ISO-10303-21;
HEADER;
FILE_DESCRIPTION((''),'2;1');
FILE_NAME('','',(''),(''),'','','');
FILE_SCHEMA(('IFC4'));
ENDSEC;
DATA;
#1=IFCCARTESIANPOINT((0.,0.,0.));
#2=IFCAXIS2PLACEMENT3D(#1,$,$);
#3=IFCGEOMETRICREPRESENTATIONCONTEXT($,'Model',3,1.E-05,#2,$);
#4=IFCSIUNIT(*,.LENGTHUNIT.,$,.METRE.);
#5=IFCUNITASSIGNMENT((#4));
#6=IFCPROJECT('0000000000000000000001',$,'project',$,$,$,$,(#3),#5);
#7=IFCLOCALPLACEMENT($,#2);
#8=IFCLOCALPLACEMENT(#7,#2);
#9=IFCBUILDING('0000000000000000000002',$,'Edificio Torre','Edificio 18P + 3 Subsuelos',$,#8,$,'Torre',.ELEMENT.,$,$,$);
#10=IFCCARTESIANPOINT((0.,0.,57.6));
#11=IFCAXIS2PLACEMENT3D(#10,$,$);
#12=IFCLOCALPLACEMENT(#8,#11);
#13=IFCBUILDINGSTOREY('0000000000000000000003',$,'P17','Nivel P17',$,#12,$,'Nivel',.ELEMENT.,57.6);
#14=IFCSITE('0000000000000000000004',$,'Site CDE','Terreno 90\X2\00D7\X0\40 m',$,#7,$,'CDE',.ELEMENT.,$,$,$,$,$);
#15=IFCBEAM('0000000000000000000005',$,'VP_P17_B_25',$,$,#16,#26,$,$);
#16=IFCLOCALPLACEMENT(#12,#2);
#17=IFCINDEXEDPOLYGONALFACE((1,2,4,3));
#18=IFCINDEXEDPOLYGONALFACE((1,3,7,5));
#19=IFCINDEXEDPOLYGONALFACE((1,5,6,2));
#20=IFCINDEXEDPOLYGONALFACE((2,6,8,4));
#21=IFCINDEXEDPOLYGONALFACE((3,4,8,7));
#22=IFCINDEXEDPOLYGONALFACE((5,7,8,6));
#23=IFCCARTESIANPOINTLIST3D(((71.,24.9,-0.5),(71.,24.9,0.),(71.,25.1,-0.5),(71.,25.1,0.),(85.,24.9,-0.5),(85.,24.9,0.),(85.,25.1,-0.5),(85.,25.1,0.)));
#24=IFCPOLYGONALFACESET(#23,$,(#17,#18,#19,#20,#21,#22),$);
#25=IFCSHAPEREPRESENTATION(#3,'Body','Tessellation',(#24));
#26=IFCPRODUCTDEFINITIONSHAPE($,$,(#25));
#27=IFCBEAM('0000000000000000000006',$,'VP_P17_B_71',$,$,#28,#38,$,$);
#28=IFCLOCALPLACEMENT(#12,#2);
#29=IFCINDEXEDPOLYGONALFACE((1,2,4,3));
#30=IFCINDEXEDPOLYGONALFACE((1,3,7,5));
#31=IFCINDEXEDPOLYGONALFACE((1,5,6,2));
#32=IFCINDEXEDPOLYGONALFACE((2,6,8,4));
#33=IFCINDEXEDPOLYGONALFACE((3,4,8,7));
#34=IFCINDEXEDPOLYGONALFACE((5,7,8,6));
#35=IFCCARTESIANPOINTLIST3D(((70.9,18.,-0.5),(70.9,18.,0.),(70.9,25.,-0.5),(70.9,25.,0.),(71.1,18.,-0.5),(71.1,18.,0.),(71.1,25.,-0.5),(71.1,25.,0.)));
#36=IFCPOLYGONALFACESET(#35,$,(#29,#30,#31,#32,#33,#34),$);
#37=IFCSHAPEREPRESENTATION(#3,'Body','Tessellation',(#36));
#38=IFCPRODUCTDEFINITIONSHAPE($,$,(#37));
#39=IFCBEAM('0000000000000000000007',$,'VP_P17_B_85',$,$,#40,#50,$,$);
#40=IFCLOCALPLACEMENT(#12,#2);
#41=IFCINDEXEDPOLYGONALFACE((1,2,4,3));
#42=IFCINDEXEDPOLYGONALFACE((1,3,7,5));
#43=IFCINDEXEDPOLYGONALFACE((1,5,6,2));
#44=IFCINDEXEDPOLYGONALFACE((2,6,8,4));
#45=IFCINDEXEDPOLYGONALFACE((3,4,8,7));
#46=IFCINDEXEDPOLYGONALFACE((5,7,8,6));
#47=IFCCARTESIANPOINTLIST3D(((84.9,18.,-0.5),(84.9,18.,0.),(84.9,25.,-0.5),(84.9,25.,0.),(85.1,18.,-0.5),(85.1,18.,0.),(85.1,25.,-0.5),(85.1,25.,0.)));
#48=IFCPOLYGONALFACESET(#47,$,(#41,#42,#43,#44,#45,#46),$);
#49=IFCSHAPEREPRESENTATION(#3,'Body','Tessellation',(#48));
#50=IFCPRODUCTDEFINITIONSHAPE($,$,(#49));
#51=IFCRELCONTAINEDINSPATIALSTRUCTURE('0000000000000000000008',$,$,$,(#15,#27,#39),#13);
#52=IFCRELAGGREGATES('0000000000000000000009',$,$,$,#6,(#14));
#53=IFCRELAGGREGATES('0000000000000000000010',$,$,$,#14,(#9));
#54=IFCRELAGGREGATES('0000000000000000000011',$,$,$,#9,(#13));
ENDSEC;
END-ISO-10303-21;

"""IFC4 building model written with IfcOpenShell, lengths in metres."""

from ifc_helpers import new_model, si_unit, frame, origin, origin_2d, place, context, project, spatial, rectangle, extrude, element, save


model = new_model("IFC4")

# Units and contexts
model_context = context("Model", 3, precision=1e-05, world=origin())
ifc_project = project(units=[si_unit("LENGTHUNIT", "METRE")], contexts=[model_context])

# Site, building, storey
site_placement = place(None, origin())
site = spatial("IfcSite", under=ifc_project, at=site_placement, Name="Site CDE", Description="Terreno 90×40 m", LongName="CDE", CompositionType="ELEMENT")
building_placement = place(site_placement, origin())
building = spatial("IfcBuilding", under=site, at=building_placement, Name="Edificio Torre", Description="Edificio 18P + 3 Subsuelos", LongName="Torre", CompositionType="ELEMENT")
storey_placement = place(building_placement, frame((0.0, 0.0, 57.6)))
storey = spatial("IfcBuildingStorey", under=building, at=storey_placement, Name="P17", Description="Nivel P17", LongName="Nivel", CompositionType="ELEMENT", Elevation=57.6)

# Beams
for number, where, name in (
    (1, (78.0, 25.0, -0.5), "VP_P17_B_25"),
):
    element("IfcBeam", number, at=place(storey_placement, frame(where)), inside=storey, Name=name, context=model_context, shape_type="SweptSolid", body=[
        extrude(rectangle(XDim=14.0, YDim=0.2, at=origin_2d()), origin(), (0.0, 0.0, 1.0), 0.5),
    ])
for number, where, name in (
    (2, (71.0, 21.5, -0.5), "VP_P17_B_71"),
    (3, (85.0, 21.5, -0.5), "VP_P17_B_85"),
):
    element("IfcBeam", number, at=place(storey_placement, frame(where)), inside=storey, Name=name, context=model_context, shape_type="SweptSolid", body=[
        extrude(rectangle(XDim=0.2, YDim=7.0, at=origin_2d()), origin(), (0.0, 0.0, 1.0), 0.5),
    ])

save(model, "model.ifc")
